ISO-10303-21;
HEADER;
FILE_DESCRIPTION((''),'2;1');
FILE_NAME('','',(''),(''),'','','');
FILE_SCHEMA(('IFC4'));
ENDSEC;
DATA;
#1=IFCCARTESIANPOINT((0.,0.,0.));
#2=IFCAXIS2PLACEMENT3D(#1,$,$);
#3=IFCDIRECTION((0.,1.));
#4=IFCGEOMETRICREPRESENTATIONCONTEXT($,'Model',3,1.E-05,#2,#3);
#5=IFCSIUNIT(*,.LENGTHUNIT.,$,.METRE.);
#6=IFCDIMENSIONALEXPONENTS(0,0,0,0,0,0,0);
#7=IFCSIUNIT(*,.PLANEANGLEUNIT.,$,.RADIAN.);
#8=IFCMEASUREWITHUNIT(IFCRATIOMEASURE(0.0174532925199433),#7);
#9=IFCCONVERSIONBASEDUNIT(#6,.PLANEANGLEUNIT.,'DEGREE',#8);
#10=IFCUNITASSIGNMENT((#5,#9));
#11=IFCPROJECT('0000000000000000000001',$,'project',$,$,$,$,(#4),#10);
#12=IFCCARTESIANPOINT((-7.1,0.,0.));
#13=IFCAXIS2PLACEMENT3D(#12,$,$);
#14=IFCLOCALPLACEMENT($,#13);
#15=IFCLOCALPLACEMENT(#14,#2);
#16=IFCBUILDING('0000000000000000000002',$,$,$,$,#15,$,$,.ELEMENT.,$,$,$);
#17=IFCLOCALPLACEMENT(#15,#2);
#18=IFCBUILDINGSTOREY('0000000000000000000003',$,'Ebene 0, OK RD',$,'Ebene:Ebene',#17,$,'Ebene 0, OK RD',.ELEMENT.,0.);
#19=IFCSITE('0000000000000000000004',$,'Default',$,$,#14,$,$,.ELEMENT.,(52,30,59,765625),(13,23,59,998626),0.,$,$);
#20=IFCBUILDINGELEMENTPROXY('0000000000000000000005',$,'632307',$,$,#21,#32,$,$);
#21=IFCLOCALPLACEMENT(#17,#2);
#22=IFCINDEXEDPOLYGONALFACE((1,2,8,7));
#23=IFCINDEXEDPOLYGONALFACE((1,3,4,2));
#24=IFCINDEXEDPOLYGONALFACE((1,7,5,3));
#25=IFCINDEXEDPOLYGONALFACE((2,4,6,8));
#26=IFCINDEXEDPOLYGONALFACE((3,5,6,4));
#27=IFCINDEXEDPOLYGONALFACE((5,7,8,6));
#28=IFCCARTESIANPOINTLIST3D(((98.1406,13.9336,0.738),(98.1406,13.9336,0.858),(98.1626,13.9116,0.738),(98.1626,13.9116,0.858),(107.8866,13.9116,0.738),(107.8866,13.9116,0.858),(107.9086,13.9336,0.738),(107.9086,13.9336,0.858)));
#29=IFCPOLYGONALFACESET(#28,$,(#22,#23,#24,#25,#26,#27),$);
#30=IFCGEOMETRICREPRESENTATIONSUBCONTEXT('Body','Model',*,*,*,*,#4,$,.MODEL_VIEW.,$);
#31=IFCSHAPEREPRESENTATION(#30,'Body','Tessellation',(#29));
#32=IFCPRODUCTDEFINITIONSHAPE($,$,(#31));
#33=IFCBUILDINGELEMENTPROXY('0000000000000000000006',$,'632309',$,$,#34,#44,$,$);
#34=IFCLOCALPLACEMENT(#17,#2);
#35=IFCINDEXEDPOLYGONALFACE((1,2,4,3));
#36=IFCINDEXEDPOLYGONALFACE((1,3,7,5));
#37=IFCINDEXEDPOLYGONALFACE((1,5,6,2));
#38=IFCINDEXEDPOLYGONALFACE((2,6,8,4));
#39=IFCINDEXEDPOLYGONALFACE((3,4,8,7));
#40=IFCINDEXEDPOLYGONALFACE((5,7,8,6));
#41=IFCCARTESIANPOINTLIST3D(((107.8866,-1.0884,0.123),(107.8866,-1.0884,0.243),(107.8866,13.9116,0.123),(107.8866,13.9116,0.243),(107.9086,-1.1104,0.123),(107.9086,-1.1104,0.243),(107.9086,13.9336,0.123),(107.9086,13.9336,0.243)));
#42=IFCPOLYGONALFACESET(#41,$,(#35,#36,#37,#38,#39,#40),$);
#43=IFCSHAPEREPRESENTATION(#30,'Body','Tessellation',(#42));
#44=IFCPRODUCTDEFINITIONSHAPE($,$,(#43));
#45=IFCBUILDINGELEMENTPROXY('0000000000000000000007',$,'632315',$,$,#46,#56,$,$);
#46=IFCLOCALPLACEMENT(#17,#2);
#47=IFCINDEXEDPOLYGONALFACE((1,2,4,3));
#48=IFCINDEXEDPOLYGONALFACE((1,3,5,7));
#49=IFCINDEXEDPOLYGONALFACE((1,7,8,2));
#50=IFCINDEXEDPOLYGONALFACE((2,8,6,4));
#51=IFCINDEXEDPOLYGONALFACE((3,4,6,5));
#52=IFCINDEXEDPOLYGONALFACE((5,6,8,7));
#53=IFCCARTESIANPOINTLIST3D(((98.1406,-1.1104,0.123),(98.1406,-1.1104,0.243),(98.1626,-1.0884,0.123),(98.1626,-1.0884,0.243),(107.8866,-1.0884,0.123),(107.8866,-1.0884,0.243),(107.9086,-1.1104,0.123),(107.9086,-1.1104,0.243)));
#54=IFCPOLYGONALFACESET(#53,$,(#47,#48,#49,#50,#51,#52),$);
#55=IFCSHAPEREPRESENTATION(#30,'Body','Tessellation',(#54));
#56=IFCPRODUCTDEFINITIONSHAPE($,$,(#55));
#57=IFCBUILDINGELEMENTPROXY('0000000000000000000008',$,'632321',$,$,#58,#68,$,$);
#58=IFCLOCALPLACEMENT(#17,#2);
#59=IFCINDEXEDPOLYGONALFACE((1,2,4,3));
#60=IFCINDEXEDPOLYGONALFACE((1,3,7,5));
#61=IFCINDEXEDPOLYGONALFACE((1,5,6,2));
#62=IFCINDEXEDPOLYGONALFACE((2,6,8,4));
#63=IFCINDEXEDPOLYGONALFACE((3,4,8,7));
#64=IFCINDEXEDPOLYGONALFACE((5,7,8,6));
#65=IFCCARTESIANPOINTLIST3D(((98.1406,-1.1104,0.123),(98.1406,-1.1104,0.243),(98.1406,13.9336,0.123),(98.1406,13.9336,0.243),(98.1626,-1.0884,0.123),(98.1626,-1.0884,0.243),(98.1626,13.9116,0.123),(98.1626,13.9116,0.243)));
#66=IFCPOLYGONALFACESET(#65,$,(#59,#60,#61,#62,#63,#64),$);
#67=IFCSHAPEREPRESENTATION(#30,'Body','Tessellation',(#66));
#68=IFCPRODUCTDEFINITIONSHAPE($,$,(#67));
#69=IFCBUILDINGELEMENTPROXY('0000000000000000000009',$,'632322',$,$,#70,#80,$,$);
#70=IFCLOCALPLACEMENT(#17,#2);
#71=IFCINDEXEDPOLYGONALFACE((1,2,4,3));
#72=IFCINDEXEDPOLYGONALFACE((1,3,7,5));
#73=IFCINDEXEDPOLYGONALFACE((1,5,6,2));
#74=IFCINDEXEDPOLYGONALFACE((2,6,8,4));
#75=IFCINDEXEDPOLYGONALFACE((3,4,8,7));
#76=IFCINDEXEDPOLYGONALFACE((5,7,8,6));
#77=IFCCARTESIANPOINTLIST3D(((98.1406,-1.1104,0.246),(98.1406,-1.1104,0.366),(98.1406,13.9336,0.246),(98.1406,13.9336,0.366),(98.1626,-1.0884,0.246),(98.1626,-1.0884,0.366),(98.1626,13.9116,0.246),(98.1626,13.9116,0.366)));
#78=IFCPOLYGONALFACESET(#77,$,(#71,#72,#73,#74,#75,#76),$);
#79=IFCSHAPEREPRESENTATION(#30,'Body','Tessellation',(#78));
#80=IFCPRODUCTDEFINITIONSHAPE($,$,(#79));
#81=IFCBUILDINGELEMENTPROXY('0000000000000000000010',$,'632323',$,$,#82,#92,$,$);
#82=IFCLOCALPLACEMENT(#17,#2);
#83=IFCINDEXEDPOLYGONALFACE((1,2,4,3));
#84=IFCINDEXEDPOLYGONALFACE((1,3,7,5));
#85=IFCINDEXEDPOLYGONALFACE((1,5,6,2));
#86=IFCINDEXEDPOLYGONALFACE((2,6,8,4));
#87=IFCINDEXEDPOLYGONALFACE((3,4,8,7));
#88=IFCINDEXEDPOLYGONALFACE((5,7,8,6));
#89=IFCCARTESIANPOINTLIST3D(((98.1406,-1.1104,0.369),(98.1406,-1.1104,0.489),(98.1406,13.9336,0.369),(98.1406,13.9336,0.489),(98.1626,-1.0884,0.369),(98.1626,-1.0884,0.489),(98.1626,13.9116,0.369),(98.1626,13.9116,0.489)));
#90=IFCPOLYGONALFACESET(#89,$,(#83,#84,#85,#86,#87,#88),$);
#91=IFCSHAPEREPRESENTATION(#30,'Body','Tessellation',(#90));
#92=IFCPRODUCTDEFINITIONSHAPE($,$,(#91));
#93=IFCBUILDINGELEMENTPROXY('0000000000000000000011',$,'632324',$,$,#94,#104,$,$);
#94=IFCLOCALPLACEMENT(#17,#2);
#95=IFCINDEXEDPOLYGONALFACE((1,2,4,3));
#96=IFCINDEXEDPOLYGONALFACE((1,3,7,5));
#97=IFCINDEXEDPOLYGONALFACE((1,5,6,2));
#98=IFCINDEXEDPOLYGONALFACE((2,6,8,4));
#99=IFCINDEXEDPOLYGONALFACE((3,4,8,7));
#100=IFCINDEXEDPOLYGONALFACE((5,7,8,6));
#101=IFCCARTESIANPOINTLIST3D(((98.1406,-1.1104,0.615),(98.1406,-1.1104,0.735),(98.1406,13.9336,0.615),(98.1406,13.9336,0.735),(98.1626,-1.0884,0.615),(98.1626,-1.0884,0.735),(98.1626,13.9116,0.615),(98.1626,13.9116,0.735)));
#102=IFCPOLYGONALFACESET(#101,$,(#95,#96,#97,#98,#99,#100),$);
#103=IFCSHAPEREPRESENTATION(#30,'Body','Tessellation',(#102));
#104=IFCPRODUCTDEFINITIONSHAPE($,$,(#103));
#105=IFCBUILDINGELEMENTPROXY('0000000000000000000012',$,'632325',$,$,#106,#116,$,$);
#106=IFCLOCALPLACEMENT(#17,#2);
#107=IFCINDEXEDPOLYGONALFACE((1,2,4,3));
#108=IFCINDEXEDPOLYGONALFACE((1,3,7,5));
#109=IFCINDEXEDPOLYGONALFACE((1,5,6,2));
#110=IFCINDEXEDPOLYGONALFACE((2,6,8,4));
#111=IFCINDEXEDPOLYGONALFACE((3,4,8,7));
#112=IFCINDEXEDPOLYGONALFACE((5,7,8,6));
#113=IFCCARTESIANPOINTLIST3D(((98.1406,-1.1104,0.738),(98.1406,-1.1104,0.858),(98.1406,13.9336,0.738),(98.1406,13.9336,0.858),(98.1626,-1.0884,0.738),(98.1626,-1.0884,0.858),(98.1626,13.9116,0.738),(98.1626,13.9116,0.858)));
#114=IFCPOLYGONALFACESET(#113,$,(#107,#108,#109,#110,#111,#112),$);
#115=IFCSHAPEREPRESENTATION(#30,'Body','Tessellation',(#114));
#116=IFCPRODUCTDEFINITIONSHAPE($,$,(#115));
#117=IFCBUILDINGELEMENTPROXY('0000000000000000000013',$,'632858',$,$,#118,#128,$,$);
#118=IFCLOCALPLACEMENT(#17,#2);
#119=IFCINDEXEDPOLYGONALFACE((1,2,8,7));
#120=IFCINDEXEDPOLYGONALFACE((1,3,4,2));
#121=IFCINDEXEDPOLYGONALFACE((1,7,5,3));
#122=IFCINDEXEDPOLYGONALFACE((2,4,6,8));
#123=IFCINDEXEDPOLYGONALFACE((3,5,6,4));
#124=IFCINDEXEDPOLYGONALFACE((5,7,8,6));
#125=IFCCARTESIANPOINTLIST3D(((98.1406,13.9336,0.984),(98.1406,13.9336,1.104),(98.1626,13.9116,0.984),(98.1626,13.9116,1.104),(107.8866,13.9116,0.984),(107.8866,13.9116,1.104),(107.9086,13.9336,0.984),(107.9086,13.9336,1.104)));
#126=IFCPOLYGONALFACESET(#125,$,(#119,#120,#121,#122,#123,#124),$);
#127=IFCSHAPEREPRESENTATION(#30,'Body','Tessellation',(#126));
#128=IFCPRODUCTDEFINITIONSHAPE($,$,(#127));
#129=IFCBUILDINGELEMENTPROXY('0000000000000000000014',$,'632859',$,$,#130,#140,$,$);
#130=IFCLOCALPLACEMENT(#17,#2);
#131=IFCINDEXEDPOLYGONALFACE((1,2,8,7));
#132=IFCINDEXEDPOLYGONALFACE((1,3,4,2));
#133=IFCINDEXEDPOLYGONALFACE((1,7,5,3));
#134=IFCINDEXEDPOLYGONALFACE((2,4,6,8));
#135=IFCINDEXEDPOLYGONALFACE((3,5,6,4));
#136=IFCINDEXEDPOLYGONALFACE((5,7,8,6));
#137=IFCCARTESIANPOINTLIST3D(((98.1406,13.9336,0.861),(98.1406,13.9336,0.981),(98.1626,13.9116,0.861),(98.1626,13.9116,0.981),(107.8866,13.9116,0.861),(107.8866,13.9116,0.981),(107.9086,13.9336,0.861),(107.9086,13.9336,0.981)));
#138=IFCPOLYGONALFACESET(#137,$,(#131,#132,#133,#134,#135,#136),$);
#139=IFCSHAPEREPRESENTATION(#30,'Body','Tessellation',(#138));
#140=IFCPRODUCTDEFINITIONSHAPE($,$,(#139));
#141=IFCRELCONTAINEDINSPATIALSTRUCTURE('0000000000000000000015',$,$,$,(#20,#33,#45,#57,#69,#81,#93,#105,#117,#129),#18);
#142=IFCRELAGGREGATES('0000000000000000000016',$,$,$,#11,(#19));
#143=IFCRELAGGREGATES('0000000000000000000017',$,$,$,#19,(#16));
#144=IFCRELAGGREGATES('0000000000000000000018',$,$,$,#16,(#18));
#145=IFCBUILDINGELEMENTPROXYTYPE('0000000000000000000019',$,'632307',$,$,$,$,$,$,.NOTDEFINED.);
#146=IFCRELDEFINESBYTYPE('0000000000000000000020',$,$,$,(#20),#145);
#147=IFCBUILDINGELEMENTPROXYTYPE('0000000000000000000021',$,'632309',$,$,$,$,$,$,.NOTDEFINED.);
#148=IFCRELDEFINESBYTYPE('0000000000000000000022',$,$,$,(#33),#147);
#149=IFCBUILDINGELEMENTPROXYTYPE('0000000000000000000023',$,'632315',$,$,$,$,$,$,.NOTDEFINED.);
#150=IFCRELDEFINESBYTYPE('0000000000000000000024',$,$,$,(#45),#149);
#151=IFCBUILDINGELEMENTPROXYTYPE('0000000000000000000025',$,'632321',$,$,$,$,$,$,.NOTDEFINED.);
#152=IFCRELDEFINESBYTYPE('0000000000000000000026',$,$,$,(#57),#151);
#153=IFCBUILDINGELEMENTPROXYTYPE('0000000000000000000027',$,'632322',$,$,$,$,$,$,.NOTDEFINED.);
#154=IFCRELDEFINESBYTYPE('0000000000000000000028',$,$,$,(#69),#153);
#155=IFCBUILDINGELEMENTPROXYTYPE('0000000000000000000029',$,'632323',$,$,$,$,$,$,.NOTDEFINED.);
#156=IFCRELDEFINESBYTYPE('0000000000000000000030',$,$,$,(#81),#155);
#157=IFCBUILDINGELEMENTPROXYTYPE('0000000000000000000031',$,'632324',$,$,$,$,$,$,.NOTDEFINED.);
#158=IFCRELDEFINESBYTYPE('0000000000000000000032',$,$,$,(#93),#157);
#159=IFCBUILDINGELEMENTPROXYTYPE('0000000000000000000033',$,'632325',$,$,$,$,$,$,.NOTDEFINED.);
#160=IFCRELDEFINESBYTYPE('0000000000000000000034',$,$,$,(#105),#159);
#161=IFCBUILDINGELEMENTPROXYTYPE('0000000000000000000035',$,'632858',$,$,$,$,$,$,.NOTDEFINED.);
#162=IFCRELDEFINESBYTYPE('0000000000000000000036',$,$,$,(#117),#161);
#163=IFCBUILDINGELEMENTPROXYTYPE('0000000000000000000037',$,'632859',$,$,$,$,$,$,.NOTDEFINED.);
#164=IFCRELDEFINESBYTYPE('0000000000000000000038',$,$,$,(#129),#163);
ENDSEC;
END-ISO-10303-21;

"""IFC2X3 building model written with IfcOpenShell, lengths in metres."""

from ifc_helpers import new_model, entity, si_unit, converted_unit, direction, frame, origin, place, context, subcontext, project, spatial, polyline, outline, extrude, type_object, element, save


model = new_model("IFC2X3")

# Units and contexts
model_context = context("Model", 3, precision=1e-05, world=origin(), true_north=direction((0.0, 1.0)))
body_context = subcontext(model_context, "Body", "Model", "MODEL_VIEW")
ifc_project = project(units=[si_unit("LENGTHUNIT", "METRE"), converted_unit("PLANEANGLEUNIT", "DEGREE", entity("IfcRatioMeasure", 0.0174532925199433), si_unit("PLANEANGLEUNIT", "RADIAN"), dimensions=[0, 0, 0, 0, 0, 0, 0])], contexts=[model_context])

# Site, building, storey
site_placement = place(None, frame((-7.1, 0.0, 0.0)))
site = spatial("IfcSite", under=ifc_project, at=site_placement, Name="Default", CompositionType="ELEMENT", RefLatitude=(52, 30, 59, 765625), RefLongitude=(13, 23, 59, 998626), RefElevation=0.0)
building_placement = place(site_placement, origin())
building = spatial("IfcBuilding", under=site, at=building_placement, CompositionType="ELEMENT")
storey_placement = place(building_placement, origin())
storey = spatial("IfcBuildingStorey", under=building, at=storey_placement, Name="Ebene 0, OK RD", ObjectType="Ebene:Ebene", LongName="Ebene 0, OK RD", CompositionType="ELEMENT", Elevation=0.0)

# Building element proxies
building_element_proxy_type_1 = type_object("IfcBuildingElementProxyType", Name="632307", PredefinedType="NOTDEFINED")
proxy_1_placement = place(storey_placement, origin())
element("IfcBuildingElementProxy", 1, at=proxy_1_placement, inside=storey, type_object=building_element_proxy_type_1, Name="632307", context=body_context, shape_type="SweptSolid", body=[
    extrude(outline(polyline([(-4.862, -0.011), (4.862, -0.011), (4.884, 0.011), (-4.884, 0.011), (-4.862, -0.011)])), frame((103.0246, 13.9226, 0.738)), (0.0, 0.0, 1.0), 0.12),
])
building_element_proxy_type_2 = type_object("IfcBuildingElementProxyType", Name="632309", PredefinedType="NOTDEFINED")
proxy_2_placement = place(storey_placement, origin())
element("IfcBuildingElementProxy", 2, at=proxy_2_placement, inside=storey, type_object=building_element_proxy_type_2, Name="632309", context=body_context, shape_type="SweptSolid", body=[
    extrude(outline(polyline([(-7.5, -0.011), (7.5, -0.011), (7.522, 0.011), (-7.522, 0.011), (-7.5, -0.011)])), frame((107.8976, 6.4116, 0.123), z_axis=(0.0, 0.0, 1.0), x_axis=(0.0, -1.0, 0.0)), (0.0, 0.0, 1.0), 0.12),
])
building_element_proxy_type_3 = type_object("IfcBuildingElementProxyType", Name="632315", PredefinedType="NOTDEFINED")
proxy_3_placement = place(storey_placement, origin())
element("IfcBuildingElementProxy", 3, at=proxy_3_placement, inside=storey, type_object=building_element_proxy_type_3, Name="632315", context=body_context, shape_type="SweptSolid", body=[
    extrude(outline(polyline([(-4.862, -0.011), (4.862, -0.011), (4.884, 0.011), (-4.884, 0.011), (-4.862, -0.011)])), frame((103.0246, -1.0994, 0.123), z_axis=(0.0, 0.0, 1.0), x_axis=(-1.0, 0.0, 0.0)), (0.0, 0.0, 1.0), 0.12),
])
building_element_proxy_type_4 = type_object("IfcBuildingElementProxyType", Name="632321", PredefinedType="NOTDEFINED")
proxy_4_placement = place(storey_placement, origin())
element("IfcBuildingElementProxy", 4, at=proxy_4_placement, inside=storey, type_object=building_element_proxy_type_4, Name="632321", context=body_context, shape_type="SweptSolid", body=[
    extrude(outline(polyline([(-7.5, -0.011), (7.5, -0.011), (7.522, 0.011), (-7.522, 0.011), (-7.5, -0.011)])), frame((98.1516, 6.4116, 0.123), z_axis=(0.0, 0.0, 1.0), x_axis=(0.0, 1.0, 0.0)), (0.0, 0.0, 1.0), 0.12),
])
building_element_proxy_type_5 = type_object("IfcBuildingElementProxyType", Name="632322", PredefinedType="NOTDEFINED")
proxy_5_placement = place(storey_placement, origin())
element("IfcBuildingElementProxy", 5, at=proxy_5_placement, inside=storey, type_object=building_element_proxy_type_5, Name="632322", context=body_context, shape_type="SweptSolid", body=[
    extrude(outline(polyline([(-7.5, -0.011), (7.5, -0.011), (7.522, 0.011), (-7.522, 0.011), (-7.5, -0.011)])), frame((98.1516, 6.4116, 0.246), z_axis=(0.0, 0.0, 1.0), x_axis=(0.0, 1.0, 0.0)), (0.0, 0.0, 1.0), 0.12),
])
building_element_proxy_type_6 = type_object("IfcBuildingElementProxyType", Name="632323", PredefinedType="NOTDEFINED")
proxy_6_placement = place(storey_placement, origin())
element("IfcBuildingElementProxy", 6, at=proxy_6_placement, inside=storey, type_object=building_element_proxy_type_6, Name="632323", context=body_context, shape_type="SweptSolid", body=[
    extrude(outline(polyline([(-7.5, -0.011), (7.5, -0.011), (7.522, 0.011), (-7.522, 0.011), (-7.5, -0.011)])), frame((98.1516, 6.4116, 0.369), z_axis=(0.0, 0.0, 1.0), x_axis=(0.0, 1.0, 0.0)), (0.0, 0.0, 1.0), 0.12),
])
building_element_proxy_type_7 = type_object("IfcBuildingElementProxyType", Name="632324", PredefinedType="NOTDEFINED")
proxy_7_placement = place(storey_placement, origin())
element("IfcBuildingElementProxy", 7, at=proxy_7_placement, inside=storey, type_object=building_element_proxy_type_7, Name="632324", context=body_context, shape_type="SweptSolid", body=[
    extrude(outline(polyline([(-7.5, -0.011), (7.5, -0.011), (7.522, 0.011), (-7.522, 0.011), (-7.5, -0.011)])), frame((98.1516, 6.4116, 0.615), z_axis=(0.0, 0.0, 1.0), x_axis=(0.0, 1.0, 0.0)), (0.0, 0.0, 1.0), 0.12),
])
building_element_proxy_type_8 = type_object("IfcBuildingElementProxyType", Name="632325", PredefinedType="NOTDEFINED")
proxy_8_placement = place(storey_placement, origin())
element("IfcBuildingElementProxy", 8, at=proxy_8_placement, inside=storey, type_object=building_element_proxy_type_8, Name="632325", context=body_context, shape_type="SweptSolid", body=[
    extrude(outline(polyline([(-7.5, -0.011), (7.5, -0.011), (7.522, 0.011), (-7.522, 0.011), (-7.5, -0.011)])), frame((98.1516, 6.4116, 0.738), z_axis=(0.0, 0.0, 1.0), x_axis=(0.0, 1.0, 0.0)), (0.0, 0.0, 1.0), 0.12),
])
building_element_proxy_type_9 = type_object("IfcBuildingElementProxyType", Name="632858", PredefinedType="NOTDEFINED")
proxy_9_placement = place(storey_placement, origin())
element("IfcBuildingElementProxy", 9, at=proxy_9_placement, inside=storey, type_object=building_element_proxy_type_9, Name="632858", context=body_context, shape_type="SweptSolid", body=[
    extrude(outline(polyline([(-4.862, -0.011), (4.862, -0.011), (4.884, 0.011), (-4.884, 0.011), (-4.862, -0.011)])), frame((103.0246, 13.9226, 0.984)), (0.0, 0.0, 1.0), 0.12),
])
building_element_proxy_type_10 = type_object("IfcBuildingElementProxyType", Name="632859", PredefinedType="NOTDEFINED")
proxy_10_placement = place(storey_placement, origin())
element("IfcBuildingElementProxy", 10, at=proxy_10_placement, inside=storey, type_object=building_element_proxy_type_10, Name="632859", context=body_context, shape_type="SweptSolid", body=[
    extrude(outline(polyline([(-4.862, -0.011), (4.862, -0.011), (4.884, 0.011), (-4.884, 0.011), (-4.862, -0.011)])), frame((103.0246, 13.9226, 0.861)), (0.0, 0.0, 1.0), 0.12),
])

save(model, "model.ifc")
